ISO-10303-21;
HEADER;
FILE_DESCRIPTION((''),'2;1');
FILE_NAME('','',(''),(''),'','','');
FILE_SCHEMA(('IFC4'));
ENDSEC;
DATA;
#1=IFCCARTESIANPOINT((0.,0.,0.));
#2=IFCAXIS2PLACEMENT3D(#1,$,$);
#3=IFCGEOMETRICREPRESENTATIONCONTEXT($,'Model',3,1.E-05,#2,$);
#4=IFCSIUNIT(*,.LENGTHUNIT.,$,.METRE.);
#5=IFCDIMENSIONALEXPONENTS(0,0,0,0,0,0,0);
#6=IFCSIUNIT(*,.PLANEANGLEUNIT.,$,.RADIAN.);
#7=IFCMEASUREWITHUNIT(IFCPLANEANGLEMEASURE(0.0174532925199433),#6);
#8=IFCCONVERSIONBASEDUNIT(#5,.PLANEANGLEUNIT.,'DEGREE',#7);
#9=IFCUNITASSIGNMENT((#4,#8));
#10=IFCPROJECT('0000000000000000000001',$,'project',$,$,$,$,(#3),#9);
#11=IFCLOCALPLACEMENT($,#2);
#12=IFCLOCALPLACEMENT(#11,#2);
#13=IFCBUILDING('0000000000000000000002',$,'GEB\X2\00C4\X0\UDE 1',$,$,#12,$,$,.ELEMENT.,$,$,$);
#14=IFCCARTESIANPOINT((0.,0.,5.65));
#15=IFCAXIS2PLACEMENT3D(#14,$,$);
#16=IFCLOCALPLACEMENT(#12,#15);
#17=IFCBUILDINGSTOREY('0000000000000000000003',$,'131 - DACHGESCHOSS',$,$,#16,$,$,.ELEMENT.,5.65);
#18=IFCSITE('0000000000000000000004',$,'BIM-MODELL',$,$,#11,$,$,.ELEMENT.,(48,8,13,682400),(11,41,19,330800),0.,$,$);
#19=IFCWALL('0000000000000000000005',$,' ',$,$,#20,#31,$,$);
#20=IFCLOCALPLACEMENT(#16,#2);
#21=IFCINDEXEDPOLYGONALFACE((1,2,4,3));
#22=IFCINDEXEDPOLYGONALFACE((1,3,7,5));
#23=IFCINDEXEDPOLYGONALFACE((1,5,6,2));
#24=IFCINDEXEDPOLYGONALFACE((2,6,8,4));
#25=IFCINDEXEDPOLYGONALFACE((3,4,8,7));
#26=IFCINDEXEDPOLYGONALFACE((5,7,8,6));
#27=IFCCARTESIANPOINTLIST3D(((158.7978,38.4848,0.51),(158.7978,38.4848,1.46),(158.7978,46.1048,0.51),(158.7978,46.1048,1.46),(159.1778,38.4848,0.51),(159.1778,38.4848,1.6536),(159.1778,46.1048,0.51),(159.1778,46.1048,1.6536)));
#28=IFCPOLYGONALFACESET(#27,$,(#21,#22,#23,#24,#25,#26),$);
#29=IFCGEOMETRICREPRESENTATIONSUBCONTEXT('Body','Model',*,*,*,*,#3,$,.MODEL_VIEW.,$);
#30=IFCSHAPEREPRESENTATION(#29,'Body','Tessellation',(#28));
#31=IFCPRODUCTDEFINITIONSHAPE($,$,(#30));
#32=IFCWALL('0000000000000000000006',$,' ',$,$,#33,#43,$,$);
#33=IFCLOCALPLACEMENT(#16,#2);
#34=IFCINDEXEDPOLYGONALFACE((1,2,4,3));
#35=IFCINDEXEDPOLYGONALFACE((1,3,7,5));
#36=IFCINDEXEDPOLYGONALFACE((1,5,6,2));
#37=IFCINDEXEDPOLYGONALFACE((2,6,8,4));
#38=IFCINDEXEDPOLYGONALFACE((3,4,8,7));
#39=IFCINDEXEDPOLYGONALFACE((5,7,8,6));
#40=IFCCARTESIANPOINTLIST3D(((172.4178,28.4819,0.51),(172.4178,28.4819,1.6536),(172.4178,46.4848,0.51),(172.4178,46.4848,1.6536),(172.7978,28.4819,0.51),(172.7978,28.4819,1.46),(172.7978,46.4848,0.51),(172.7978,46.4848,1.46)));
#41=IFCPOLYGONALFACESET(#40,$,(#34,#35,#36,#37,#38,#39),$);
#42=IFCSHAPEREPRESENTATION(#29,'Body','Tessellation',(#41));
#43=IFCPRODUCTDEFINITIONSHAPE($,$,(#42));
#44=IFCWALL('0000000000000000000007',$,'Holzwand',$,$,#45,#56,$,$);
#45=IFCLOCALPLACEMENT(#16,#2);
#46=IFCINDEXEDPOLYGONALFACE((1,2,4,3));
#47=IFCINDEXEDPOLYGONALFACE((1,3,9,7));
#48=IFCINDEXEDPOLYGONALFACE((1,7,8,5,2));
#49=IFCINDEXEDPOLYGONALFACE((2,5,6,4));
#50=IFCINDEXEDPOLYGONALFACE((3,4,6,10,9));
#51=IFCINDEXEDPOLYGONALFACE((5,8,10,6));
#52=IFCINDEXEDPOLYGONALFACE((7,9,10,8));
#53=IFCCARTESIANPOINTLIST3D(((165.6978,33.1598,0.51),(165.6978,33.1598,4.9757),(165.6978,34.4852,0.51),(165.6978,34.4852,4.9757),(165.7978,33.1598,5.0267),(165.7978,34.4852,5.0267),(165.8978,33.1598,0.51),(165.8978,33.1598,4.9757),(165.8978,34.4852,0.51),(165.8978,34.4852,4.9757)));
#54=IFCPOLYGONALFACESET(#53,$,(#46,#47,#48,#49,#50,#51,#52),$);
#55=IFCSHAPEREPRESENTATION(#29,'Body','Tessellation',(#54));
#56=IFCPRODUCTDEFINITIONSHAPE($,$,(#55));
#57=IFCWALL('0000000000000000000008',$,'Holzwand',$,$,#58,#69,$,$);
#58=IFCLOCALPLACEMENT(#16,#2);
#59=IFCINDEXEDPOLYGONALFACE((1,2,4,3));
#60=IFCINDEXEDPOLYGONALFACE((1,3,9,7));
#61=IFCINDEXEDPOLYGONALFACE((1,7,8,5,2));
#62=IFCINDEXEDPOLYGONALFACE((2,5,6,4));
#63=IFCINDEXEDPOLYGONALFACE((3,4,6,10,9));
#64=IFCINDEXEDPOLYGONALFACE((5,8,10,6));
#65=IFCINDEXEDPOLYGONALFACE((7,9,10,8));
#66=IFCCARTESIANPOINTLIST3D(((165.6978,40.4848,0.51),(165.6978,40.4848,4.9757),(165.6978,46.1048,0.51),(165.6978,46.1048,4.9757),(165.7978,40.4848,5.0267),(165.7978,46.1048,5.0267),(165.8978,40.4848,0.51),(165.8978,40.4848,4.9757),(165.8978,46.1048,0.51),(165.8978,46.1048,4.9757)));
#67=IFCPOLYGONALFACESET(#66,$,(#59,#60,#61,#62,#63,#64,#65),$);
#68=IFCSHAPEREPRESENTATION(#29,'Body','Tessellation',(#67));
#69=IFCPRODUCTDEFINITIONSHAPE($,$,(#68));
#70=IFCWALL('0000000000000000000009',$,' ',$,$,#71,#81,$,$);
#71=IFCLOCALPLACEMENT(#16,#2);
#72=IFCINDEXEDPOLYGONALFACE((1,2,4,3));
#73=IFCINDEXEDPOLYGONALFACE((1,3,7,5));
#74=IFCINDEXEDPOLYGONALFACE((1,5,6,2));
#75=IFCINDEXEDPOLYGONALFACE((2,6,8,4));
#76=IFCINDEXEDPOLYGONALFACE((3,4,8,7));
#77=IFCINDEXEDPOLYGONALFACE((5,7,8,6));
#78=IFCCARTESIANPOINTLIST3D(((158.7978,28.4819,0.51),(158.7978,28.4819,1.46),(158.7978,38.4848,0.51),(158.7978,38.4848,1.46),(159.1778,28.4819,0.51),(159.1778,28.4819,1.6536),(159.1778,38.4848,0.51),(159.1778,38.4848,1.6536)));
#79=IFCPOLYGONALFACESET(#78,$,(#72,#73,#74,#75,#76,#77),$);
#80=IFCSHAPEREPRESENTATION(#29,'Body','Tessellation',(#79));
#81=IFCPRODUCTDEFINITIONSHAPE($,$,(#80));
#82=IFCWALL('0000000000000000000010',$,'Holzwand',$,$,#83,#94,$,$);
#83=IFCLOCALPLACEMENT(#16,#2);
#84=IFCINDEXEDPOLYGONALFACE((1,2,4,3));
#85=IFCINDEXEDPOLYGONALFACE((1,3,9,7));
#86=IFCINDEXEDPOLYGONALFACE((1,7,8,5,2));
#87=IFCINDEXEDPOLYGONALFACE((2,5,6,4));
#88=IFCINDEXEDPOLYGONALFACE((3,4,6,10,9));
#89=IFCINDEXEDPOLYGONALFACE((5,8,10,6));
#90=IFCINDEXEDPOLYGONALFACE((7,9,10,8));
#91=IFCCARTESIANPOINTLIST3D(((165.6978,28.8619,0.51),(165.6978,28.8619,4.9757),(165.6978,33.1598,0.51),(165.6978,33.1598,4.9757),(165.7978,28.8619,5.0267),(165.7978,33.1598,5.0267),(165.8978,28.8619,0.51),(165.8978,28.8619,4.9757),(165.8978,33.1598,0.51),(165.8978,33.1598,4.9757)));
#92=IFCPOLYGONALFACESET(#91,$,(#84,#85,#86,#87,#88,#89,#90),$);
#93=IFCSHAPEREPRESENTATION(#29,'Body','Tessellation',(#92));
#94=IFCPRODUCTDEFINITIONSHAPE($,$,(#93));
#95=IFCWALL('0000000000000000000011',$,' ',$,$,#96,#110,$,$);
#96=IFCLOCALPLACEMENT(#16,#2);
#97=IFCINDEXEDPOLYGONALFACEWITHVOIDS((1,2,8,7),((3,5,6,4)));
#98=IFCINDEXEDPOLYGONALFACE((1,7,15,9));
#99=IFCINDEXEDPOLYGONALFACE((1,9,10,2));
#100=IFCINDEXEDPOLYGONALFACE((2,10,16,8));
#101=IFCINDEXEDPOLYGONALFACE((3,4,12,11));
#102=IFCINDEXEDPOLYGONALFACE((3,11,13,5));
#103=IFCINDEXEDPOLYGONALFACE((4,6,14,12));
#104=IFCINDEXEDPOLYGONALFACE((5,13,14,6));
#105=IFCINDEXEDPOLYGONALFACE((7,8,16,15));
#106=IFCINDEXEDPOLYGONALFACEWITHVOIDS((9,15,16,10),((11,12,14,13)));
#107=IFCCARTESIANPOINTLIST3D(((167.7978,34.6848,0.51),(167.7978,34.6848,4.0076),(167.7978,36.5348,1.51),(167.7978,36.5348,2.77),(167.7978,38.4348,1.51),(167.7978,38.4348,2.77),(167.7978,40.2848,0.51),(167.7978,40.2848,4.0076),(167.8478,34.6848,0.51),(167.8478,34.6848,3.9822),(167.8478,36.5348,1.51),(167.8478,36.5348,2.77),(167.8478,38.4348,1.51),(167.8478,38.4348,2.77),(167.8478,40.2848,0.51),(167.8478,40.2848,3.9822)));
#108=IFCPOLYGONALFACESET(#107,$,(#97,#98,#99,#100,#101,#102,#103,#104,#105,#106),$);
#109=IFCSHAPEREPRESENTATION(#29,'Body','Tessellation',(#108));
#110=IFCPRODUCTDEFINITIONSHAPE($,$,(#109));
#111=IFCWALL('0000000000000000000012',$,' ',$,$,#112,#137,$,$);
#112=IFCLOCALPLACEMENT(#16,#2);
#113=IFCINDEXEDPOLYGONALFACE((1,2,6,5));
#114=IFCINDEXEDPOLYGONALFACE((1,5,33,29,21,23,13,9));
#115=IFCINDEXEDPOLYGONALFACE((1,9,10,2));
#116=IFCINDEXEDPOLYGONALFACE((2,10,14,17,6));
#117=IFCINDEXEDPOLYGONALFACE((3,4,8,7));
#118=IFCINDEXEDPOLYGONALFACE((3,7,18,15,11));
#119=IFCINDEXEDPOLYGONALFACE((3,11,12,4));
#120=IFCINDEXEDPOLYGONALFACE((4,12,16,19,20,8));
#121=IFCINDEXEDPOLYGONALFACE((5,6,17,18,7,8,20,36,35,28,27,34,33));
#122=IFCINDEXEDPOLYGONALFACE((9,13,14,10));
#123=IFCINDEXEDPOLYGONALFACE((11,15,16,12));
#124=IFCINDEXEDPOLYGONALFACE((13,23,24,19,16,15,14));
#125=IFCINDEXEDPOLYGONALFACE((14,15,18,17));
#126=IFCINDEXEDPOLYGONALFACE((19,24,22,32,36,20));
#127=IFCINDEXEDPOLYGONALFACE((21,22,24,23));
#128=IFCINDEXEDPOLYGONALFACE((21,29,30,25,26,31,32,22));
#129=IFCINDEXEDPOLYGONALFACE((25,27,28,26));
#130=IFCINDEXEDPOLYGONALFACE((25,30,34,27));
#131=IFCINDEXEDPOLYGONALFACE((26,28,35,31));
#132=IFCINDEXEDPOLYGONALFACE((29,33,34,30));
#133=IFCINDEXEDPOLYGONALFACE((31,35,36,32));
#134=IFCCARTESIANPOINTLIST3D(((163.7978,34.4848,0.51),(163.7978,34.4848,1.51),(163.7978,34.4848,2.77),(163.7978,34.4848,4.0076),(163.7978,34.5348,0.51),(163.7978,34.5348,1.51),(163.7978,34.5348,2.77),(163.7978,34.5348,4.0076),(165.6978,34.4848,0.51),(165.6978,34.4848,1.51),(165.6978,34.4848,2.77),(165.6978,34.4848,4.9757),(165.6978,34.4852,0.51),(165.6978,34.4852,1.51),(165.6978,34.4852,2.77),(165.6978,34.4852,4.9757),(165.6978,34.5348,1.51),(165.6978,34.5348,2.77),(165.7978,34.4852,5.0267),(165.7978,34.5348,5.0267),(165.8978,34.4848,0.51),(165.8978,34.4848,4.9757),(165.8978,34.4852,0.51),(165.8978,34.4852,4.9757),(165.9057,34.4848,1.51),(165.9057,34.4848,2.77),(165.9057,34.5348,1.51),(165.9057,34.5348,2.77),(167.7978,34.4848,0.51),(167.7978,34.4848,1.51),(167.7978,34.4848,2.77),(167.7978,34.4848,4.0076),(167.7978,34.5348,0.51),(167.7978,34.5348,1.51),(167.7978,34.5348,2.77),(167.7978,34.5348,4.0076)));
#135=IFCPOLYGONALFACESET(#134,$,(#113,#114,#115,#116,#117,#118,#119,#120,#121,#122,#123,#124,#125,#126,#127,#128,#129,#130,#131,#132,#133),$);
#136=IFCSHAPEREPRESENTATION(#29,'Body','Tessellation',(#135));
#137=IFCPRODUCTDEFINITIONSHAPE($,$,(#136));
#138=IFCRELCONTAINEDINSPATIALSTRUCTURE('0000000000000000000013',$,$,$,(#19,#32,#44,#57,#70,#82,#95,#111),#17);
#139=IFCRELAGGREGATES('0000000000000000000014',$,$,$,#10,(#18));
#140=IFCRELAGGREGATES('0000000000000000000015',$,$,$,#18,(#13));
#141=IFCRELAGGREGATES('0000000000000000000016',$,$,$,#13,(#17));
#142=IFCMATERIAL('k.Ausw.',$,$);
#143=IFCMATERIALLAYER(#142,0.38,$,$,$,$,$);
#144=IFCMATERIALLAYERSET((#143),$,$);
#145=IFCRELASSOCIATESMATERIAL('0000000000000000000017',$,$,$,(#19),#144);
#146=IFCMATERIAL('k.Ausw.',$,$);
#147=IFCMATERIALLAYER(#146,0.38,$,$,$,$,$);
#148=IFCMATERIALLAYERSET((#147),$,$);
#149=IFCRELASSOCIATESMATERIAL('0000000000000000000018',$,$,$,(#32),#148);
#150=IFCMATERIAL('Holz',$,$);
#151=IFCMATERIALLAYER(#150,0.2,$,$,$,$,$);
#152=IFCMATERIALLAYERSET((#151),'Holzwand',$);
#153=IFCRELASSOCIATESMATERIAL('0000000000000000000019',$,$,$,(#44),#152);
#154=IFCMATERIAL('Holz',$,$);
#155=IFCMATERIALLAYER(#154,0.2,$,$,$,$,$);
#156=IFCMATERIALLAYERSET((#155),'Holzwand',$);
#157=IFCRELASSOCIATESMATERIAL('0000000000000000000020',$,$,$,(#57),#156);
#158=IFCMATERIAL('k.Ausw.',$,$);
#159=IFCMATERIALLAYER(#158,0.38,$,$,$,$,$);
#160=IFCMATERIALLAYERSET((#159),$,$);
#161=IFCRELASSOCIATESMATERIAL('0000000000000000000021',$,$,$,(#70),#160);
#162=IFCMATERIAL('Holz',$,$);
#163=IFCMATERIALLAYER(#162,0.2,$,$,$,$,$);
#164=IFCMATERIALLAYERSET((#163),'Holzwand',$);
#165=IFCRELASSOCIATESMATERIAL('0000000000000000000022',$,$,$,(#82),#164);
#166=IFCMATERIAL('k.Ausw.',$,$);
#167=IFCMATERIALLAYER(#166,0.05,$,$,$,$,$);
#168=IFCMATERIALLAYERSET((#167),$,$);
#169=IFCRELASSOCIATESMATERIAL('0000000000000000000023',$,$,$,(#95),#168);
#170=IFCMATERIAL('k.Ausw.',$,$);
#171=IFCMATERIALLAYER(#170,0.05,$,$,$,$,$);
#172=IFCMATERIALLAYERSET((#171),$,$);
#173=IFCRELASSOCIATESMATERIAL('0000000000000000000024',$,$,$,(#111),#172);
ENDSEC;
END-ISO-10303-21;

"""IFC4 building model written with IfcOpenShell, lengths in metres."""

from ifc_helpers import new_model, entity, si_unit, converted_unit, frame, frame_2d, origin, origin_with_axes, place, context, subcontext, project, spatial, polyline, rectangle, outline, extrude, clip, halfspace, bounded_halfspace, material, layer, layer_set, layer_usage, element, save


model = new_model("IFC4")

# Units and contexts
model_context = context("Model", 3, precision=1e-05, world=origin())
body_context = subcontext(model_context, "Body", "Model", "MODEL_VIEW")
ifc_project = project(units=[si_unit("LENGTHUNIT", "METRE"), converted_unit("PLANEANGLEUNIT", "DEGREE", entity("IfcPlaneAngleMeasure", 0.0174532925199433), si_unit("PLANEANGLEUNIT", "RADIAN"), dimensions=[0, 0, 0, 0, 0, 0, 0])], contexts=[model_context])

# Site, building, storey
site_placement = place(None, origin())
site = spatial("IfcSite", under=ifc_project, at=site_placement, Name="BIM-MODELL", CompositionType="ELEMENT", RefLatitude=(48, 8, 13, 682400), RefLongitude=(11, 41, 19, 330800), RefElevation=0.0)
building_placement = place(site_placement, origin())
building = spatial("IfcBuilding", under=site, at=building_placement, Name="GEBÄUDE 1", CompositionType="ELEMENT")
storey_placement = place(building_placement, frame((0.0, 0.0, 5.65)))
storey = spatial("IfcBuildingStorey", under=building, at=storey_placement, Name="131 - DACHGESCHOSS", CompositionType="ELEMENT", Elevation=5.65)

# Walls
ifc_material_1 = material(Name="k.Ausw.")
ifc_layer_1 = layer(ifc_material_1, 0.38)
ifc_layer_set_1 = layer_set([ifc_layer_1])
ifc_layer_usage_1 = layer_usage(ifc_layer_set_1, "AXIS2", "POSITIVE", 0.0)
wall_1_placement = place(storey_placement, frame((158.7978, 46.1048, 0.51), z_axis=(0.0, 0.0, 1.0), x_axis=(0.0, -1.0, 0.0)))
element("IfcWall", 1, at=wall_1_placement, inside=storey, material=ifc_layer_usage_1, Name=" ", context=body_context, shape_type="Clipping", body=[
    clip(extrude(rectangle(XDim=7.62, YDim=0.38, at=frame_2d((3.81, 0.19), x_axis=(1.0, 0.0))), origin_with_axes(), (0.0, 0.0, 1.0), 1.1436), halfspace(frame((3.81, 0.19, 1.0468), z_axis=(0.0, 0.45399, -0.891007), x_axis=(0.0, -0.891007, -0.45399)), True)),
])
ifc_material_2 = material(Name="k.Ausw.")
ifc_layer_2 = layer(ifc_material_2, 0.38)
ifc_layer_set_2 = layer_set([ifc_layer_2])
ifc_layer_usage_2 = layer_usage(ifc_layer_set_2, "AXIS2", "POSITIVE", 0.0)
wall_2_placement = place(storey_placement, frame((172.7978, 28.4819, 0.51), z_axis=(0.0, 0.0, 1.0), x_axis=(0.0, 1.0, 0.0)))
element("IfcWall", 2, at=wall_2_placement, inside=storey, material=ifc_layer_usage_2, Name=" ", context=body_context, shape_type="Clipping", body=[
    clip(extrude(rectangle(XDim=18.0029, YDim=0.38, at=frame_2d((9.0014, 0.19), x_axis=(1.0, 0.0))), origin_with_axes(), (0.0, 0.0, 1.0), 1.1436), halfspace(frame((9.0014, 0.19, 1.0468), z_axis=(0.0, 0.45399, -0.891007), x_axis=(0.0, -0.891007, -0.45399)), True)),
])
ifc_material_3 = material(Name="Holz")
ifc_layer_3 = layer(ifc_material_3, 0.2)
ifc_layer_set_3 = layer_set([ifc_layer_3], Name="Holzwand")
ifc_layer_usage_3 = layer_usage(ifc_layer_set_3, "AXIS2", "POSITIVE", 0.0)
wall_3_placement = place(storey_placement, frame((165.6978, 34.4852, 0.51), z_axis=(0.0, 0.0, 1.0), x_axis=(0.0, -1.0, 0.0)))
element("IfcWall", 3, at=wall_3_placement, inside=storey, material=ifc_layer_usage_3, Name="Holzwand", context=body_context, shape_type="Clipping", body=[
    clip(clip(extrude(rectangle(XDim=1.3254, YDim=0.2, at=frame_2d((0.6627, 0.1), x_axis=(1.0, 0.0))), origin_with_axes(), (0.0, 0.0, 1.0), 4.5167), bounded_halfspace(frame((0.6627, 0.15, 4.4912), z_axis=(0.0, -0.45399, -0.891007), x_axis=(0.0, -0.891007, 0.45399)), True, origin_with_axes(), polyline([(0.0, 0.2), (0.0, 0.1), (1.3254, 0.1), (1.3254, 0.2), (0.0, 0.2)]))), bounded_halfspace(frame((0.6627, 0.05, 4.4912), z_axis=(0.0, 0.45399, -0.891007), x_axis=(1.0, 0.0, 0.0)), True, origin_with_axes(), polyline([(0.0, 0.0), (1.3254, 0.0), (1.3254, 0.1), (0.0, 0.1), (0.0, 0.0)]))),
])
ifc_material_4 = material(Name="Holz")
ifc_layer_4 = layer(ifc_material_4, 0.2)
ifc_layer_set_4 = layer_set([ifc_layer_4], Name="Holzwand")
ifc_layer_usage_4 = layer_usage(ifc_layer_set_4, "AXIS2", "POSITIVE", 0.0)
wall_4_placement = place(storey_placement, frame((165.6978, 46.1048, 0.51), z_axis=(0.0, 0.0, 1.0), x_axis=(0.0, -1.0, 0.0)))
element("IfcWall", 4, at=wall_4_placement, inside=storey, material=ifc_layer_usage_4, Name="Holzwand", context=body_context, shape_type="Clipping", body=[
    clip(clip(extrude(rectangle(XDim=5.62, YDim=0.2, at=frame_2d((2.81, 0.1), x_axis=(1.0, 0.0))), origin_with_axes(), (0.0, 0.0, 1.0), 4.5167), bounded_halfspace(frame((2.81, 0.15, 4.4912), z_axis=(0.0, -0.45399, -0.891007), x_axis=(0.0, -0.891007, 0.45399)), True, origin_with_axes(), polyline([(0.0, 0.2), (0.0, 0.1), (5.62, 0.1), (5.62, 0.2), (0.0, 0.2)]))), bounded_halfspace(frame((2.81, 0.05, 4.4912), z_axis=(0.0, 0.45399, -0.891007), x_axis=(1.0, 0.0, 0.0)), True, origin_with_axes(), polyline([(0.0, 0.0), (5.62, 0.0), (5.62, 0.1), (0.0, 0.1), (0.0, 0.0)]))),
])
ifc_material_5 = material(Name="k.Ausw.")
ifc_layer_5 = layer(ifc_material_5, 0.38)
ifc_layer_set_5 = layer_set([ifc_layer_5])
ifc_layer_usage_5 = layer_usage(ifc_layer_set_5, "AXIS2", "POSITIVE", 0.0)
wall_5_placement = place(storey_placement, frame((158.7978, 38.4848, 0.51), z_axis=(0.0, 0.0, 1.0), x_axis=(0.0, -1.0, 0.0)))
element("IfcWall", 5, at=wall_5_placement, inside=storey, material=ifc_layer_usage_5, Name=" ", context=body_context, shape_type="Clipping", body=[
    clip(extrude(rectangle(XDim=10.0029, YDim=0.38, at=frame_2d((5.0014, 0.19), x_axis=(1.0, 0.0))), origin_with_axes(), (0.0, 0.0, 1.0), 1.1436), halfspace(frame((5.0014, 0.19, 1.0468), z_axis=(0.0, 0.45399, -0.891007), x_axis=(0.0, -0.891007, -0.45399)), True)),
])
ifc_material_6 = material(Name="Holz")
ifc_layer_6 = layer(ifc_material_6, 0.2)
ifc_layer_set_6 = layer_set([ifc_layer_6], Name="Holzwand")
ifc_layer_usage_6 = layer_usage(ifc_layer_set_6, "AXIS2", "POSITIVE", 0.0)
wall_6_placement = place(storey_placement, frame((165.6978, 33.1598, 0.51), z_axis=(0.0, 0.0, 1.0), x_axis=(0.0, -1.0, 0.0)))
element("IfcWall", 6, at=wall_6_placement, inside=storey, material=ifc_layer_usage_6, Name="Holzwand", context=body_context, shape_type="Clipping", body=[
    clip(clip(extrude(rectangle(XDim=4.2979, YDim=0.2, at=frame_2d((2.1489, 0.1), x_axis=(1.0, 0.0))), origin_with_axes(), (0.0, 0.0, 1.0), 4.5167), bounded_halfspace(frame((2.1489, 0.15, 4.4912), z_axis=(0.0, -0.45399, -0.891007), x_axis=(0.0, -0.891007, 0.45399)), True, origin_with_axes(), polyline([(0.0, 0.2), (0.0, 0.1), (4.2979, 0.1), (4.2979, 0.2), (0.0, 0.2)]))), bounded_halfspace(frame((2.1489, 0.05, 4.4912), z_axis=(0.0, 0.45399, -0.891007), x_axis=(1.0, 0.0, 0.0)), True, origin_with_axes(), polyline([(0.0, 0.0), (4.2979, 0.0), (4.2979, 0.1), (0.0, 0.1), (0.0, 0.0)]))),
])

# Wall, opening
ifc_material_7 = material(Name="k.Ausw.")
ifc_layer_7 = layer(ifc_material_7, 0.05)
ifc_layer_set_7 = layer_set([ifc_layer_7])
ifc_layer_usage_7 = layer_usage(ifc_layer_set_7, "AXIS2", "POSITIVE", 0.0)
wall_7_placement = place(storey_placement, frame((167.8478, 34.6848, 0.51), z_axis=(0.0, 0.0, 1.0), x_axis=(0.0, 1.0, 0.0)))
wall_7 = element("IfcWall", 7, at=wall_7_placement, inside=storey, material=ifc_layer_usage_7, Name=" ", context=body_context, shape_type="Clipping", body=[
    clip(extrude(rectangle(XDim=5.6, YDim=0.05, at=frame_2d((2.8, 0.025), x_axis=(1.0, 0.0))), origin_with_axes(), (0.0, 0.0, 1.0), 3.4976), halfspace(frame((2.8, 0.025, 3.4849), z_axis=(0.0, 0.45399, -0.891007), x_axis=(1.0, 0.0, 0.0)), True)),
])
opening_1_placement = place(wall_7_placement, frame((1.85, 0.0, 1.0), z_axis=(0.0, 1.0, 0.0), x_axis=(0.0, 0.0, 1.0)))
element("IfcOpeningElement", 8, at=opening_1_placement, cuts=wall_7, ObjectType="Opening", context=body_context, shape_type="SweptSolid", body=[
    extrude(outline(polyline([(0.0, 1.9), (1.26, 1.9), (1.26, 0.0), (0.0, 0.0), (0.0, 1.9)])), origin_with_axes(), (0.0, 0.0, 1.0), 0.05),
])

# Wall, openings
ifc_material_8 = material(Name="k.Ausw.")
ifc_layer_8 = layer(ifc_material_8, 0.05)
ifc_layer_set_8 = layer_set([ifc_layer_8])
ifc_layer_usage_8 = layer_usage(ifc_layer_set_8, "AXIS2", "POSITIVE", 0.0)
wall_8_placement = place(storey_placement, frame((163.7978, 34.4848, 0.51), z_axis=(0.0, 0.0, 1.0), x_axis=(1.0, 0.0, 0.0)))
wall_8 = element("IfcWall", 9, at=wall_8_placement, inside=storey, material=ifc_layer_usage_8, Name=" ", context=body_context, shape_type="Clipping", body=[
    clip(clip(extrude(outline(polyline([(0.0, 0.0), (1.9, 0.0), (1.9, 0.0004), (2.1, 0.0004), (2.1, 0.0), (4.0, 0.0), (4.0, 0.05), (0.0, 0.05), (0.0, 0.0)])), origin_with_axes(), (0.0, 0.0, 1.0), 4.5167), bounded_halfspace(frame((2.7, 0.0168, 4.16), z_axis=(-0.45399, 0.0, -0.891007), x_axis=(-0.891007, 0.0, 0.45399)), True, origin_with_axes(), polyline([(4.0, 0.05), (2.0, 0.05), (2.0, 0.0004), (2.1, 0.0004), (2.1, 0.0), (4.0, 0.0), (4.0, 0.05)]))), bounded_halfspace(frame((1.3, 0.0168, 4.16), z_axis=(0.45399, 0.0, -0.891007), x_axis=(0.891007, 0.0, 0.45399)), True, origin_with_axes(), polyline([(0.0, 0.0), (1.9, 0.0), (1.9, 0.0004), (2.0, 0.0004), (2.0, 0.05), (0.0, 0.05), (0.0, 0.0)]))),
])
opening_2_placement = place(wall_8_placement, frame((0.0, 0.0, 1.0), z_axis=(0.0, 1.0, 0.0), x_axis=(0.0, 0.0, 1.0)))
element("IfcOpeningElement", 10, at=opening_2_placement, cuts=wall_8, ObjectType="Opening", context=body_context, shape_type="SweptSolid", body=[
    extrude(outline(polyline([(0.0, 1.9), (1.26, 1.9), (1.26, 0.0), (0.0, 0.0), (0.0, 1.9)])), origin_with_axes(), (0.0, 0.0, 1.0), 0.05),
])
opening_3_placement = place(wall_8_placement, frame((2.108, 0.0, 1.0), z_axis=(0.0, 1.0, 0.0), x_axis=(0.0, 0.0, 1.0)))
element("IfcOpeningElement", 11, at=opening_3_placement, cuts=wall_8, ObjectType="Opening", context=body_context, shape_type="SweptSolid", body=[
    extrude(outline(polyline([(0.0, 1.892), (1.26, 1.892), (1.26, 0.0), (0.0, 0.0), (0.0, 1.892)])), origin_with_axes(), (0.0, 0.0, 1.0), 0.05),
])

save(model, "model.ifc")
